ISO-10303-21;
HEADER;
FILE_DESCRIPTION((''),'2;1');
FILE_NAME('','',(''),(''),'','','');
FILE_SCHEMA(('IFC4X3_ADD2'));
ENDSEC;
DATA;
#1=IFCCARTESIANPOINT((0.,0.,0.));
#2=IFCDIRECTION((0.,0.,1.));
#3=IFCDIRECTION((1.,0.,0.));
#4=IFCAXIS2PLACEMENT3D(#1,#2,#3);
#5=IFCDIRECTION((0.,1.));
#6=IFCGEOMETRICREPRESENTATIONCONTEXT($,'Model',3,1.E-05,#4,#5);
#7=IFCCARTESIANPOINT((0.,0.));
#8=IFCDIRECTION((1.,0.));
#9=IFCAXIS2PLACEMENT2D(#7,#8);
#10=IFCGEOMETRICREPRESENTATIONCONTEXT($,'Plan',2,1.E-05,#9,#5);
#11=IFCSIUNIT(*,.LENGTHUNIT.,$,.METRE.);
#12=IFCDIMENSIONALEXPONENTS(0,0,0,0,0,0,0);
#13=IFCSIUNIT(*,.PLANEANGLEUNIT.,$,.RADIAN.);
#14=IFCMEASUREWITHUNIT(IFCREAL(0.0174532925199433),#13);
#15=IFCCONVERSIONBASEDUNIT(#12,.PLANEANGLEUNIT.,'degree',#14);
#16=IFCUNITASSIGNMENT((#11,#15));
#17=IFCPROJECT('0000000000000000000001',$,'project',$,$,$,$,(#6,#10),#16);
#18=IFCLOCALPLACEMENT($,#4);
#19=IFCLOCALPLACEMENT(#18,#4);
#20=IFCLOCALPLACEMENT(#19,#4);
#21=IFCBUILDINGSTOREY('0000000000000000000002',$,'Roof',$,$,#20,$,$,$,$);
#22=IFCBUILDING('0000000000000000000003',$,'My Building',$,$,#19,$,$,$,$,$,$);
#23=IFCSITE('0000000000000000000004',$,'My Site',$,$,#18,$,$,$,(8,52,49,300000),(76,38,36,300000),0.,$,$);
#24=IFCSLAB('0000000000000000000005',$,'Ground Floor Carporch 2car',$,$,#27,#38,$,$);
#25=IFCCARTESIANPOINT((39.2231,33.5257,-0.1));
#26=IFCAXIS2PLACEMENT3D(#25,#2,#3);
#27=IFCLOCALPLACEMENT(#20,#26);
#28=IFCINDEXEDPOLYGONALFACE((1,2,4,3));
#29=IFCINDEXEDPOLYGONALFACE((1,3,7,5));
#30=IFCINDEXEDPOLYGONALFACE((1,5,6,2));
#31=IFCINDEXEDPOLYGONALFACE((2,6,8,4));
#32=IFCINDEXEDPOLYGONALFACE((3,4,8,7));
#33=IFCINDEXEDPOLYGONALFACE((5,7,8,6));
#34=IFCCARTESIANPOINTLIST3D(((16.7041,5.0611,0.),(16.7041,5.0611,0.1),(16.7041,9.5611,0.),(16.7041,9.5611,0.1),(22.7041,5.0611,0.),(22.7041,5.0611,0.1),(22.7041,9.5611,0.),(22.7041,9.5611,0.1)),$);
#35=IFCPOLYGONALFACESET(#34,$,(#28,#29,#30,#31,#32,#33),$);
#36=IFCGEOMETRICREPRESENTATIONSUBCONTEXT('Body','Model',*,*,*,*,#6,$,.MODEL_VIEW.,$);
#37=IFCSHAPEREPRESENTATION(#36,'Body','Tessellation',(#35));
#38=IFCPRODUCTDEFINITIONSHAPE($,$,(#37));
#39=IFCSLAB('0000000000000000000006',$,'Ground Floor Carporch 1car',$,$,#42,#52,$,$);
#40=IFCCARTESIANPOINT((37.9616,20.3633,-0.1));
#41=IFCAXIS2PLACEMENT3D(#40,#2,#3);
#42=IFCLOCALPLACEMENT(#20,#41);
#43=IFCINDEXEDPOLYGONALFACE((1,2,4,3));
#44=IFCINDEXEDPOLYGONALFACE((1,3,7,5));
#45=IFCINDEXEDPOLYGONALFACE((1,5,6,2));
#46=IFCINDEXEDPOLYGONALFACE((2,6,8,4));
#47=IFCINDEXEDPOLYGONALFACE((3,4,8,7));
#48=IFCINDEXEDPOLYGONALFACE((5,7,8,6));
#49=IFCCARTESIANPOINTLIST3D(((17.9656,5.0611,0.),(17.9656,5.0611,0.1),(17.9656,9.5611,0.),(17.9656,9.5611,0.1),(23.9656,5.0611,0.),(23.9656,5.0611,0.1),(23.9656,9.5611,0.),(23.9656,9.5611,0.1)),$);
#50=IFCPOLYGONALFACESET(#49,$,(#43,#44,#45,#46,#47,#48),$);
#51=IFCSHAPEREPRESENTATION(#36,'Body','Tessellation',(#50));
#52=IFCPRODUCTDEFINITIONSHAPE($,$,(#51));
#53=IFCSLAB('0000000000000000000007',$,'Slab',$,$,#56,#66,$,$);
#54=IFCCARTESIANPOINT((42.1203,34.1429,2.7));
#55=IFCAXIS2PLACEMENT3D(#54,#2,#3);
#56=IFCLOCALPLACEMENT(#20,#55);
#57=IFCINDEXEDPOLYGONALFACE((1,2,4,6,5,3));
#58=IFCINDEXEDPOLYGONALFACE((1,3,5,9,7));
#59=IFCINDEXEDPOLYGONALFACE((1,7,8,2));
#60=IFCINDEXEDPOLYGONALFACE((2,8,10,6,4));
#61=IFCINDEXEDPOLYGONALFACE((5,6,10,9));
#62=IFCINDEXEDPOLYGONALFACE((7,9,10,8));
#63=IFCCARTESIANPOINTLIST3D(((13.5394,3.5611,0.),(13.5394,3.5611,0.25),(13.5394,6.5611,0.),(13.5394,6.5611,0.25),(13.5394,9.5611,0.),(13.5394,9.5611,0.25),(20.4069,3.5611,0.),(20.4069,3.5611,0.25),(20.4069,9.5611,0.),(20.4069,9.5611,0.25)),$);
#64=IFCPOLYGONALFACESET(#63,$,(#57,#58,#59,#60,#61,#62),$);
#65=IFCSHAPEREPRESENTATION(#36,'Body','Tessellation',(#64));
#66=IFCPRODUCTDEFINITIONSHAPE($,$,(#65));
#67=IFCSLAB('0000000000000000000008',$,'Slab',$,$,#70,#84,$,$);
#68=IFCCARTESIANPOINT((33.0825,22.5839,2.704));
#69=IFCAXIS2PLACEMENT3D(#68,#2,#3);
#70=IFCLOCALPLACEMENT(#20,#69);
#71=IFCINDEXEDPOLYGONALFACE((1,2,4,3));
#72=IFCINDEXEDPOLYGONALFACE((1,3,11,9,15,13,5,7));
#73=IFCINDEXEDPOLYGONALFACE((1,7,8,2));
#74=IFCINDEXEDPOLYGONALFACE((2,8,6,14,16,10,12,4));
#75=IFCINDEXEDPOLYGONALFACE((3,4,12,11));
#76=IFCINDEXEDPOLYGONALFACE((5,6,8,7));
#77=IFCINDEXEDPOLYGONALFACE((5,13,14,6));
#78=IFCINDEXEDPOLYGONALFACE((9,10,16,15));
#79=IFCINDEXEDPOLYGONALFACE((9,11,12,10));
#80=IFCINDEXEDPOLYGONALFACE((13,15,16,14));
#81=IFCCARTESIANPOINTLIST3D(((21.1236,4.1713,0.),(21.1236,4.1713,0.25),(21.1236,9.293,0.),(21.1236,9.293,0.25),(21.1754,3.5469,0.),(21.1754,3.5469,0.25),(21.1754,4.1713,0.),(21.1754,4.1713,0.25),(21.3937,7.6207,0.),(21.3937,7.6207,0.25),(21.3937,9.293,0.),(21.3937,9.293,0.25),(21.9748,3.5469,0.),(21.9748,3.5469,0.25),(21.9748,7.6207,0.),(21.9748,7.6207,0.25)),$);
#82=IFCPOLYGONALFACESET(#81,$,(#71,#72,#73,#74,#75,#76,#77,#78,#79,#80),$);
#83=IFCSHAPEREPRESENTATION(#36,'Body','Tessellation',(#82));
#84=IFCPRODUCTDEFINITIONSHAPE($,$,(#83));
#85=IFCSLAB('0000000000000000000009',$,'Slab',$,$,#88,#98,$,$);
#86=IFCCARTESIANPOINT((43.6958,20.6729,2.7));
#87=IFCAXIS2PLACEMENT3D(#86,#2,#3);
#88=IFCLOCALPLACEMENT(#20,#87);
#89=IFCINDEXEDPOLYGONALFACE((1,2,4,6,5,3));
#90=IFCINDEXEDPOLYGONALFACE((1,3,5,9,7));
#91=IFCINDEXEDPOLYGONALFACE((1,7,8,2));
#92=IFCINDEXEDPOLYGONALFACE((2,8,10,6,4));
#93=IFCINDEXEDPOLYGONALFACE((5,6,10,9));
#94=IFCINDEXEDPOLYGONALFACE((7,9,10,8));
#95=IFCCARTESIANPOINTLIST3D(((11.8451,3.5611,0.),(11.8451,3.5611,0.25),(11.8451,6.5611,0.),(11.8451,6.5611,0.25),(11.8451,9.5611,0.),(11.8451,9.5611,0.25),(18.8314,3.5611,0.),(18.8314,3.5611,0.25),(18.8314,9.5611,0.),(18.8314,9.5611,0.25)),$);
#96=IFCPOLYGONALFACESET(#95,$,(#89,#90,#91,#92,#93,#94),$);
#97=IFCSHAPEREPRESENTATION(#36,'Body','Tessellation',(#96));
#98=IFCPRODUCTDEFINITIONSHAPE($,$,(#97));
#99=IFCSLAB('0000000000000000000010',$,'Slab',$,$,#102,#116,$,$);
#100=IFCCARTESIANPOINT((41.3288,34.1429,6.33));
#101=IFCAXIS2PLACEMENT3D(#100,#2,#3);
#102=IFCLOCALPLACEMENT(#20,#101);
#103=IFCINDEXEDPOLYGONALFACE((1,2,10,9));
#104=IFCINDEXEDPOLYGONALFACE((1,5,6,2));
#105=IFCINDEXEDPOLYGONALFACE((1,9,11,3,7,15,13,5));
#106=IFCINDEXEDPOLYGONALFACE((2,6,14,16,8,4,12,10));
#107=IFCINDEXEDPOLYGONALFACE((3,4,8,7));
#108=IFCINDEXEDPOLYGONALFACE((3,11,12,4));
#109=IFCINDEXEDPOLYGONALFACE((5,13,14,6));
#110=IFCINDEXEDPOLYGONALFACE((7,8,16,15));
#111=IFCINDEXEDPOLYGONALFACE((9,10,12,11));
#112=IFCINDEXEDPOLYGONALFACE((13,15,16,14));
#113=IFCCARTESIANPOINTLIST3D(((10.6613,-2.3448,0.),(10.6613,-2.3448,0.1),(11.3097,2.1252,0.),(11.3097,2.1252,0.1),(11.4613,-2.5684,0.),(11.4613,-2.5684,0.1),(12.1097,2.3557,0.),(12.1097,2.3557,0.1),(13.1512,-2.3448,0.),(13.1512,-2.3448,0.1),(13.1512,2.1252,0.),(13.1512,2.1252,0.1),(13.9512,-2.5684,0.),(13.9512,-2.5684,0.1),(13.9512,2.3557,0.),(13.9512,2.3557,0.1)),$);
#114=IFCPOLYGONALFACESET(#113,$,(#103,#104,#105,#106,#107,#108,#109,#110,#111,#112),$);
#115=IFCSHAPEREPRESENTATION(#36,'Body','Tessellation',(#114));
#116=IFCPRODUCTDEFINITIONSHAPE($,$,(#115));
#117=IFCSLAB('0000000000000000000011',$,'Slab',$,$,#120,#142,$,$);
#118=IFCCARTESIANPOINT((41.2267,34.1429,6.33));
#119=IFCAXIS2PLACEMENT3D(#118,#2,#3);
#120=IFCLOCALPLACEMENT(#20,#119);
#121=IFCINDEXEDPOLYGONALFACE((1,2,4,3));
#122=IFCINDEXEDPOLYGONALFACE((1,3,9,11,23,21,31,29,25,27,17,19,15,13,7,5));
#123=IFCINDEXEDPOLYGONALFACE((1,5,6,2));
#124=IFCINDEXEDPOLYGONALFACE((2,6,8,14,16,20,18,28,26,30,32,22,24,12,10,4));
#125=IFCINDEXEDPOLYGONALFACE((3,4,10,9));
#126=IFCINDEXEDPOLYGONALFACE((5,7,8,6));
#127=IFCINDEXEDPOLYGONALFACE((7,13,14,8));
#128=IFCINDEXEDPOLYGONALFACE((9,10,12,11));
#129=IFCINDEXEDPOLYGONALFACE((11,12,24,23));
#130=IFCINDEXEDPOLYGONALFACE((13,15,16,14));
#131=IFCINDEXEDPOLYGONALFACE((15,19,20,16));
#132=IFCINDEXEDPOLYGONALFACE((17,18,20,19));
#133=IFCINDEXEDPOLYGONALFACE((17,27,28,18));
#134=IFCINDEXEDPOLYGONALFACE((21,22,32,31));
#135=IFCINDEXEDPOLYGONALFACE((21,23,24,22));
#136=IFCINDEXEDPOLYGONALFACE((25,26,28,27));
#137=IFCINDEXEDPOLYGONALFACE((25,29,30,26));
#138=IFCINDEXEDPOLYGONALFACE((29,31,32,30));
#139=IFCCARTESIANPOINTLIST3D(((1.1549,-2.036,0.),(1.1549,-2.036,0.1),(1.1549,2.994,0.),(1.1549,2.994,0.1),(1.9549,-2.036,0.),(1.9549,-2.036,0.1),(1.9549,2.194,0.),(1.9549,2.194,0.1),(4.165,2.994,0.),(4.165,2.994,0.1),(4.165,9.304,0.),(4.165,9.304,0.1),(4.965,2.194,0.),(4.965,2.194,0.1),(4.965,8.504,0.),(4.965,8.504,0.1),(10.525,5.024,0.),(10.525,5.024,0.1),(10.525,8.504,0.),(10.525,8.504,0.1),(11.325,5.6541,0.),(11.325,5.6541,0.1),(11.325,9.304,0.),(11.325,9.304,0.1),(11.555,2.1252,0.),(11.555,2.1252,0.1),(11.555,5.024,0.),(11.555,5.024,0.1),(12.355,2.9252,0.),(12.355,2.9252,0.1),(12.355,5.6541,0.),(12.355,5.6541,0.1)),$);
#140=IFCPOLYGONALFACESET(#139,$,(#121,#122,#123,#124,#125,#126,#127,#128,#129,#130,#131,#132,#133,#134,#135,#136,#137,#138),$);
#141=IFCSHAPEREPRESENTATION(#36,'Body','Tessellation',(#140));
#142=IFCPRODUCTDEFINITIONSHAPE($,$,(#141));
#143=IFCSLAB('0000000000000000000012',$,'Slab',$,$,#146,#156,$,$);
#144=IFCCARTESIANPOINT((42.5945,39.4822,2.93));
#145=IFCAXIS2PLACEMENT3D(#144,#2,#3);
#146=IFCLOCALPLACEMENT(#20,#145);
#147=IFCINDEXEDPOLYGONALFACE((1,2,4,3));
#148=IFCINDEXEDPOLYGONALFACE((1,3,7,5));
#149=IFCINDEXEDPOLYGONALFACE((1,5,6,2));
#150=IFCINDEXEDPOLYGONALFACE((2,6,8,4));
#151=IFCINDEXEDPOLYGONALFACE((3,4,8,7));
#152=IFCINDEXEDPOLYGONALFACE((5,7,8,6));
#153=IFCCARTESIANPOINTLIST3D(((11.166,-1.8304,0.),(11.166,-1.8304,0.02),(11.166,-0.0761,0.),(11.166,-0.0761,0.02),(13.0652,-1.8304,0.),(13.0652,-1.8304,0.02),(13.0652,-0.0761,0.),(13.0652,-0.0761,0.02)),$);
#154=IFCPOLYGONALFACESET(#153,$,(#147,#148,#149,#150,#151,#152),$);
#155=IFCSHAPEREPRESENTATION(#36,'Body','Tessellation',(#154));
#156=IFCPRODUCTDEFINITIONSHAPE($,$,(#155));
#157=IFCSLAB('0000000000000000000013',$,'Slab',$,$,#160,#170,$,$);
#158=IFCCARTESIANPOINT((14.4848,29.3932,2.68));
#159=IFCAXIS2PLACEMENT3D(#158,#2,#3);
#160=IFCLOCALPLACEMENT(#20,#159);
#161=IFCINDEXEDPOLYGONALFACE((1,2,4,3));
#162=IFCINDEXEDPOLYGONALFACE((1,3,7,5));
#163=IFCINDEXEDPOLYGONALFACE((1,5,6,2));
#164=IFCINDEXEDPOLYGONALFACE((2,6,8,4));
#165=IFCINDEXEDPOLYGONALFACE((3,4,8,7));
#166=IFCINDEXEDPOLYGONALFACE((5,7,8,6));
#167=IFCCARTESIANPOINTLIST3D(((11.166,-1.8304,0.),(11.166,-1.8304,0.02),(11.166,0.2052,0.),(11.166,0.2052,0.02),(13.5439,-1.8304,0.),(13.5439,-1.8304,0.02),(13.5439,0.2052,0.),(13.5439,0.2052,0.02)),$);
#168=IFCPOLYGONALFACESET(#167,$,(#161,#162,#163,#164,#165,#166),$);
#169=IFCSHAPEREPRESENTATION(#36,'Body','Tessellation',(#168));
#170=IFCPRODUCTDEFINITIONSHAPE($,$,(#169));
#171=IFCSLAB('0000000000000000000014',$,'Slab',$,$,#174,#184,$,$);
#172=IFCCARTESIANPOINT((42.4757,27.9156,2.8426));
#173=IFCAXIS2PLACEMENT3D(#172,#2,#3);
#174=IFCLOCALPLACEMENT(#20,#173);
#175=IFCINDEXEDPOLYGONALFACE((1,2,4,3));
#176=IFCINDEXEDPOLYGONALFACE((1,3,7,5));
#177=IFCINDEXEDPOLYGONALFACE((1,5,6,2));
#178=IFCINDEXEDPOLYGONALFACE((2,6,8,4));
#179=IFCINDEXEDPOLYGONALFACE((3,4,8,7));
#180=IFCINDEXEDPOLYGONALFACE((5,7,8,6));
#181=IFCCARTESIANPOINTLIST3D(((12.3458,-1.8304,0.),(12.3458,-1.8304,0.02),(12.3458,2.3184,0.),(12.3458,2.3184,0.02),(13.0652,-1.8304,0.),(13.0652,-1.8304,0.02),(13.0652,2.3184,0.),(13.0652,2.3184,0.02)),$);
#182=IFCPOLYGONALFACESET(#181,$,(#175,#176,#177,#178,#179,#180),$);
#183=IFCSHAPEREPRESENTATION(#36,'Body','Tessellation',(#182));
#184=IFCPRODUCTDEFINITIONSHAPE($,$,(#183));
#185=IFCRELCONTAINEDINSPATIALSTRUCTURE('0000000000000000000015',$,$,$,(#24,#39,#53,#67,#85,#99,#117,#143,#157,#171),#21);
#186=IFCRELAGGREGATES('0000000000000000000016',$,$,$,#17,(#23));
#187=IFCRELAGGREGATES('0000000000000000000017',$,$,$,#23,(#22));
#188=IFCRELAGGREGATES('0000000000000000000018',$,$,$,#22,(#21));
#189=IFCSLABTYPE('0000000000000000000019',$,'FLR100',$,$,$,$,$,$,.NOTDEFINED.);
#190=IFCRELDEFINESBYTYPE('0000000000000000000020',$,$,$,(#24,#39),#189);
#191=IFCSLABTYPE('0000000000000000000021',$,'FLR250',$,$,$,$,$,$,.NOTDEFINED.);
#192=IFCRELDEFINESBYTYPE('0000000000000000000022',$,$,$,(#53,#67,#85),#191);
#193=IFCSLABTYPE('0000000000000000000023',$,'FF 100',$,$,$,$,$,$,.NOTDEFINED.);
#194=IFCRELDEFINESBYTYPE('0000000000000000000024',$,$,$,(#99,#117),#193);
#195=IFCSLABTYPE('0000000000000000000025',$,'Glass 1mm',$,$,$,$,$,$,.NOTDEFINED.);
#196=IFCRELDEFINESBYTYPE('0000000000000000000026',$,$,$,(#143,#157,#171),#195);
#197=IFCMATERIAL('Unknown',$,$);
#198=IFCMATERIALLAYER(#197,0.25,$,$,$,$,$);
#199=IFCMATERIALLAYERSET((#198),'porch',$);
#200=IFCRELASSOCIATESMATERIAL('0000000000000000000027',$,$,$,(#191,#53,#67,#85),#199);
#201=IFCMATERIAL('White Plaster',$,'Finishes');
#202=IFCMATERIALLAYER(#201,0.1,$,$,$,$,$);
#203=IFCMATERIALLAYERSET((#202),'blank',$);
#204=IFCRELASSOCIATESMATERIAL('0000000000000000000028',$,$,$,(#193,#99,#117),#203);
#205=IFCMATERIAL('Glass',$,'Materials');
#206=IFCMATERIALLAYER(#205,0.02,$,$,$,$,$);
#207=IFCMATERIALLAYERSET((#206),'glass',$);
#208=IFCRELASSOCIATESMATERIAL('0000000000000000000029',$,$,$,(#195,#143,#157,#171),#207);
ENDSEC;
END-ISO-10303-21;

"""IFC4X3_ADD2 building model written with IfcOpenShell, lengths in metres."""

from ifc_helpers import new_model, entity, si_unit, converted_unit, direction, frame, origin_with_axes, origin_2d_with_axis, place, context, subcontext, project, spatial, indexed_curve, outline, extrude, material, layer, layer_set, layer_usage, type_object, element, save


model = new_model("IFC4X3_ADD2")

# Units and contexts
model_context = context("Model", 3, precision=1e-05, world=origin_with_axes(), true_north=direction((0.0, 1.0)))
plan_context = context("Plan", 2, precision=1e-05, world=origin_2d_with_axis(), true_north=direction((0.0, 1.0)))
body_context = subcontext(model_context, "Body", "Model", "MODEL_VIEW")
ifc_project = project(units=[si_unit("LENGTHUNIT", "METRE"), converted_unit("PLANEANGLEUNIT", "degree", entity("IfcReal", 0.0174532925199433), si_unit("PLANEANGLEUNIT", "RADIAN"), dimensions=[0, 0, 0, 0, 0, 0, 0])], contexts=[model_context, plan_context])

# Site, building, storey
site_placement = place(None, origin_with_axes())
site = spatial("IfcSite", under=ifc_project, at=site_placement, Name="My Site", RefLatitude=(8, 52, 49, 300000), RefLongitude=(76, 38, 36, 300000), RefElevation=0.0)
building_placement = place(site_placement, origin_with_axes())
building = spatial("IfcBuilding", under=site, at=building_placement, Name="My Building")
storey_placement = place(building_placement, origin_with_axes())
storey = spatial("IfcBuildingStorey", under=building, at=storey_placement, Name="Roof")

# Shared definitions
ifc_material_1 = material(Name="Unknown")

# Slabs
slab_type_1 = type_object("IfcSlabType", Name="FLR100", PredefinedType="NOTDEFINED")
slab_1_placement = place(storey_placement, frame((39.2231, 33.5257, -0.1), z_axis=(0.0, 0.0, 1.0), x_axis=(1.0, 0.0, 0.0)))
element("IfcSlab", 1, at=slab_1_placement, inside=storey, type_object=slab_type_1, Name="Ground Floor Carporch 2car", context=body_context, shape_type="SweptSolid", body=[
    extrude(outline(indexed_curve([(16.7041, 5.0611), (16.7041, 9.5611), (22.7041, 9.5611), (22.7041, 5.0611), (16.7041, 5.0611)])), origin_with_axes(), (0.0, 0.0, 1.0), 0.1),
])
slab_2_placement = place(storey_placement, frame((37.9616, 20.3633, -0.1), z_axis=(0.0, 0.0, 1.0), x_axis=(1.0, 0.0, 0.0)))
element("IfcSlab", 2, at=slab_2_placement, inside=storey, type_object=slab_type_1, Name="Ground Floor Carporch 1car", context=body_context, shape_type="SweptSolid", body=[
    extrude(outline(indexed_curve([(23.9656, 5.0611), (23.9656, 9.5611), (17.9656, 9.5611), (17.9656, 5.0611), (23.9656, 5.0611)])), origin_with_axes(), (0.0, 0.0, 1.0), 0.1),
])
ifc_layer_1 = layer(ifc_material_1, 0.25)
ifc_layer_set_1 = layer_set([ifc_layer_1], Name="porch")
ifc_layer_usage_1 = layer_usage(ifc_layer_set_1, "AXIS3", "POSITIVE", 0.0)
slab_type_2 = type_object("IfcSlabType", Name="FLR250", PredefinedType="NOTDEFINED", material=ifc_layer_set_1)
slab_3_placement = place(storey_placement, frame((42.1203, 34.1429, 2.7), z_axis=(0.0, 0.0, 1.0), x_axis=(1.0, 0.0, 0.0)))
element("IfcSlab", 3, at=slab_3_placement, inside=storey, type_object=slab_type_2, material=ifc_layer_usage_1, Name="Slab", context=body_context, shape_type="SweptSolid", body=[
    extrude(outline(indexed_curve([(13.5394, 3.5611), (13.5394, 6.5611), (13.5394, 9.5611), (20.4069, 9.5611), (20.4069, 3.5611), (13.5394, 3.5611)])), origin_with_axes(), (0.0, 0.0, 1.0), 0.25),
])
ifc_layer_usage_2 = layer_usage(ifc_layer_set_1, "AXIS3", "POSITIVE", 0.0)
slab_4_placement = place(storey_placement, frame((33.0825, 22.5839, 2.704), z_axis=(0.0, 0.0, 1.0), x_axis=(1.0, 0.0, 0.0)))
element("IfcSlab", 4, at=slab_4_placement, inside=storey, type_object=slab_type_2, material=ifc_layer_usage_2, Name="Slab", context=body_context, shape_type="SweptSolid", body=[
    extrude(outline(indexed_curve([(21.1236, 4.1713), (21.1236, 9.293), (21.3937, 9.293), (21.3937, 7.6207), (21.9748, 7.6207), (21.9748, 3.5469), (21.1754, 3.5469), (21.1754, 4.1713), (21.1236, 4.1713)])), origin_with_axes(), (0.0, 0.0, 1.0), 0.25),
])
ifc_layer_usage_3 = layer_usage(ifc_layer_set_1, "AXIS3", "POSITIVE", 0.0)
slab_5_placement = place(storey_placement, frame((43.6958, 20.6729, 2.7), z_axis=(0.0, 0.0, 1.0), x_axis=(1.0, 0.0, 0.0)))
element("IfcSlab", 5, at=slab_5_placement, inside=storey, type_object=slab_type_2, material=ifc_layer_usage_3, Name="Slab", context=body_context, shape_type="SweptSolid", body=[
    extrude(outline(indexed_curve([(11.8451, 3.5611), (18.8314, 3.5611), (18.8314, 9.5611), (11.8451, 9.5611), (11.8451, 6.5611), (11.8451, 3.5611)])), origin_with_axes(), (0.0, 0.0, 1.0), 0.25),
])
ifc_material_2 = material(Name="White Plaster", Category="Finishes")
ifc_layer_2 = layer(ifc_material_2, 0.1)
ifc_layer_set_2 = layer_set([ifc_layer_2], Name="blank")
ifc_layer_usage_4 = layer_usage(ifc_layer_set_2, "AXIS3", "POSITIVE", 0.0)
slab_type_3 = type_object("IfcSlabType", Name="FF 100", PredefinedType="NOTDEFINED", material=ifc_layer_set_2)
slab_6_placement = place(storey_placement, frame((41.3288, 34.1429, 6.33), z_axis=(0.0, 0.0, 1.0), x_axis=(1.0, 0.0, 0.0)))
element("IfcSlab", 6, at=slab_6_placement, inside=storey, type_object=slab_type_3, material=ifc_layer_usage_4, Name="Slab", context=body_context, shape_type="SweptSolid", body=[
    extrude(outline(indexed_curve([(11.3097, 2.1252), (13.1512, 2.1252), (13.1512, -2.3448), (10.6613, -2.3448), (11.4613, -2.5684), (13.9512, -2.5684), (13.9512, 2.3557), (12.1097, 2.3557), (11.3097, 2.1252)])), origin_with_axes(), (0.0, 0.0, 1.0), 0.1),
])
ifc_layer_usage_5 = layer_usage(ifc_layer_set_2, "AXIS3", "POSITIVE", 0.0)
slab_7_placement = place(storey_placement, frame((41.2267, 34.1429, 6.33), z_axis=(0.0, 0.0, 1.0), x_axis=(1.0, 0.0, 0.0)))
element("IfcSlab", 7, at=slab_7_placement, inside=storey, type_object=slab_type_3, material=ifc_layer_usage_5, Name="Slab", context=body_context, shape_type="SweptSolid", body=[
    extrude(outline(indexed_curve([(1.1549, -2.036), (1.1549, 2.994), (4.165, 2.994), (4.165, 9.304), (11.325, 9.304), (11.325, 5.6541), (12.355, 5.6541), (12.355, 2.9252), (11.555, 2.1252), (11.555, 5.024), (10.525, 5.024), (10.525, 8.504), (4.965, 8.504), (4.965, 2.194), (1.9549, 2.194), (1.9549, -2.036)])), origin_with_axes(), (0.0, 0.0, 1.0), 0.1),
])
ifc_material_3 = material(Name="Glass", Category="Materials")
ifc_layer_3 = layer(ifc_material_3, 0.02)
ifc_layer_set_3 = layer_set([ifc_layer_3], Name="glass")
ifc_layer_usage_6 = layer_usage(ifc_layer_set_3, "AXIS3", "POSITIVE", 0.0)
slab_type_4 = type_object("IfcSlabType", Name="Glass 1mm", PredefinedType="NOTDEFINED", material=ifc_layer_set_3)
slab_8_placement = place(storey_placement, frame((42.5945, 39.4822, 2.93), z_axis=(0.0, 0.0, 1.0), x_axis=(1.0, 0.0, 0.0)))
element("IfcSlab", 8, at=slab_8_placement, inside=storey, type_object=slab_type_4, material=ifc_layer_usage_6, Name="Slab", context=body_context, shape_type="SweptSolid", body=[
    extrude(outline(indexed_curve([(13.0652, -0.0761), (11.166, -0.0761), (11.166, -1.8304), (13.0652, -1.8304), (13.0652, -0.0761)])), origin_with_axes(), (0.0, 0.0, 1.0), 0.02),
])
ifc_layer_usage_7 = layer_usage(ifc_layer_set_3, "AXIS3", "POSITIVE", 0.0)
slab_9_placement = place(storey_placement, frame((14.4848, 29.3932, 2.68), z_axis=(0.0, 0.0, 1.0), x_axis=(1.0, 0.0, 0.0)))
element("IfcSlab", 9, at=slab_9_placement, inside=storey, type_object=slab_type_4, material=ifc_layer_usage_7, Name="Slab", context=body_context, shape_type="SweptSolid", body=[
    extrude(outline(indexed_curve([(13.5439, 0.2052), (11.166, 0.2052), (11.166, -1.8304), (13.5439, -1.8304), (13.5439, 0.2052)])), origin_with_axes(), (0.0, 0.0, 1.0), 0.02),
])
ifc_layer_usage_8 = layer_usage(ifc_layer_set_3, "AXIS3", "POSITIVE", 0.0)
slab_10_placement = place(storey_placement, frame((42.4757, 27.9156, 2.8426), z_axis=(0.0, 0.0, 1.0), x_axis=(1.0, 0.0, 0.0)))
element("IfcSlab", 10, at=slab_10_placement, inside=storey, type_object=slab_type_4, material=ifc_layer_usage_8, Name="Slab", context=body_context, shape_type="SweptSolid", body=[
    extrude(outline(indexed_curve([(13.0652, 2.3184), (12.3458, 2.3184), (12.3458, -1.8304), (13.0652, -1.8304), (13.0652, 2.3184)])), origin_with_axes(), (0.0, 0.0, 1.0), 0.02),
])

save(model, "model.ifc")
